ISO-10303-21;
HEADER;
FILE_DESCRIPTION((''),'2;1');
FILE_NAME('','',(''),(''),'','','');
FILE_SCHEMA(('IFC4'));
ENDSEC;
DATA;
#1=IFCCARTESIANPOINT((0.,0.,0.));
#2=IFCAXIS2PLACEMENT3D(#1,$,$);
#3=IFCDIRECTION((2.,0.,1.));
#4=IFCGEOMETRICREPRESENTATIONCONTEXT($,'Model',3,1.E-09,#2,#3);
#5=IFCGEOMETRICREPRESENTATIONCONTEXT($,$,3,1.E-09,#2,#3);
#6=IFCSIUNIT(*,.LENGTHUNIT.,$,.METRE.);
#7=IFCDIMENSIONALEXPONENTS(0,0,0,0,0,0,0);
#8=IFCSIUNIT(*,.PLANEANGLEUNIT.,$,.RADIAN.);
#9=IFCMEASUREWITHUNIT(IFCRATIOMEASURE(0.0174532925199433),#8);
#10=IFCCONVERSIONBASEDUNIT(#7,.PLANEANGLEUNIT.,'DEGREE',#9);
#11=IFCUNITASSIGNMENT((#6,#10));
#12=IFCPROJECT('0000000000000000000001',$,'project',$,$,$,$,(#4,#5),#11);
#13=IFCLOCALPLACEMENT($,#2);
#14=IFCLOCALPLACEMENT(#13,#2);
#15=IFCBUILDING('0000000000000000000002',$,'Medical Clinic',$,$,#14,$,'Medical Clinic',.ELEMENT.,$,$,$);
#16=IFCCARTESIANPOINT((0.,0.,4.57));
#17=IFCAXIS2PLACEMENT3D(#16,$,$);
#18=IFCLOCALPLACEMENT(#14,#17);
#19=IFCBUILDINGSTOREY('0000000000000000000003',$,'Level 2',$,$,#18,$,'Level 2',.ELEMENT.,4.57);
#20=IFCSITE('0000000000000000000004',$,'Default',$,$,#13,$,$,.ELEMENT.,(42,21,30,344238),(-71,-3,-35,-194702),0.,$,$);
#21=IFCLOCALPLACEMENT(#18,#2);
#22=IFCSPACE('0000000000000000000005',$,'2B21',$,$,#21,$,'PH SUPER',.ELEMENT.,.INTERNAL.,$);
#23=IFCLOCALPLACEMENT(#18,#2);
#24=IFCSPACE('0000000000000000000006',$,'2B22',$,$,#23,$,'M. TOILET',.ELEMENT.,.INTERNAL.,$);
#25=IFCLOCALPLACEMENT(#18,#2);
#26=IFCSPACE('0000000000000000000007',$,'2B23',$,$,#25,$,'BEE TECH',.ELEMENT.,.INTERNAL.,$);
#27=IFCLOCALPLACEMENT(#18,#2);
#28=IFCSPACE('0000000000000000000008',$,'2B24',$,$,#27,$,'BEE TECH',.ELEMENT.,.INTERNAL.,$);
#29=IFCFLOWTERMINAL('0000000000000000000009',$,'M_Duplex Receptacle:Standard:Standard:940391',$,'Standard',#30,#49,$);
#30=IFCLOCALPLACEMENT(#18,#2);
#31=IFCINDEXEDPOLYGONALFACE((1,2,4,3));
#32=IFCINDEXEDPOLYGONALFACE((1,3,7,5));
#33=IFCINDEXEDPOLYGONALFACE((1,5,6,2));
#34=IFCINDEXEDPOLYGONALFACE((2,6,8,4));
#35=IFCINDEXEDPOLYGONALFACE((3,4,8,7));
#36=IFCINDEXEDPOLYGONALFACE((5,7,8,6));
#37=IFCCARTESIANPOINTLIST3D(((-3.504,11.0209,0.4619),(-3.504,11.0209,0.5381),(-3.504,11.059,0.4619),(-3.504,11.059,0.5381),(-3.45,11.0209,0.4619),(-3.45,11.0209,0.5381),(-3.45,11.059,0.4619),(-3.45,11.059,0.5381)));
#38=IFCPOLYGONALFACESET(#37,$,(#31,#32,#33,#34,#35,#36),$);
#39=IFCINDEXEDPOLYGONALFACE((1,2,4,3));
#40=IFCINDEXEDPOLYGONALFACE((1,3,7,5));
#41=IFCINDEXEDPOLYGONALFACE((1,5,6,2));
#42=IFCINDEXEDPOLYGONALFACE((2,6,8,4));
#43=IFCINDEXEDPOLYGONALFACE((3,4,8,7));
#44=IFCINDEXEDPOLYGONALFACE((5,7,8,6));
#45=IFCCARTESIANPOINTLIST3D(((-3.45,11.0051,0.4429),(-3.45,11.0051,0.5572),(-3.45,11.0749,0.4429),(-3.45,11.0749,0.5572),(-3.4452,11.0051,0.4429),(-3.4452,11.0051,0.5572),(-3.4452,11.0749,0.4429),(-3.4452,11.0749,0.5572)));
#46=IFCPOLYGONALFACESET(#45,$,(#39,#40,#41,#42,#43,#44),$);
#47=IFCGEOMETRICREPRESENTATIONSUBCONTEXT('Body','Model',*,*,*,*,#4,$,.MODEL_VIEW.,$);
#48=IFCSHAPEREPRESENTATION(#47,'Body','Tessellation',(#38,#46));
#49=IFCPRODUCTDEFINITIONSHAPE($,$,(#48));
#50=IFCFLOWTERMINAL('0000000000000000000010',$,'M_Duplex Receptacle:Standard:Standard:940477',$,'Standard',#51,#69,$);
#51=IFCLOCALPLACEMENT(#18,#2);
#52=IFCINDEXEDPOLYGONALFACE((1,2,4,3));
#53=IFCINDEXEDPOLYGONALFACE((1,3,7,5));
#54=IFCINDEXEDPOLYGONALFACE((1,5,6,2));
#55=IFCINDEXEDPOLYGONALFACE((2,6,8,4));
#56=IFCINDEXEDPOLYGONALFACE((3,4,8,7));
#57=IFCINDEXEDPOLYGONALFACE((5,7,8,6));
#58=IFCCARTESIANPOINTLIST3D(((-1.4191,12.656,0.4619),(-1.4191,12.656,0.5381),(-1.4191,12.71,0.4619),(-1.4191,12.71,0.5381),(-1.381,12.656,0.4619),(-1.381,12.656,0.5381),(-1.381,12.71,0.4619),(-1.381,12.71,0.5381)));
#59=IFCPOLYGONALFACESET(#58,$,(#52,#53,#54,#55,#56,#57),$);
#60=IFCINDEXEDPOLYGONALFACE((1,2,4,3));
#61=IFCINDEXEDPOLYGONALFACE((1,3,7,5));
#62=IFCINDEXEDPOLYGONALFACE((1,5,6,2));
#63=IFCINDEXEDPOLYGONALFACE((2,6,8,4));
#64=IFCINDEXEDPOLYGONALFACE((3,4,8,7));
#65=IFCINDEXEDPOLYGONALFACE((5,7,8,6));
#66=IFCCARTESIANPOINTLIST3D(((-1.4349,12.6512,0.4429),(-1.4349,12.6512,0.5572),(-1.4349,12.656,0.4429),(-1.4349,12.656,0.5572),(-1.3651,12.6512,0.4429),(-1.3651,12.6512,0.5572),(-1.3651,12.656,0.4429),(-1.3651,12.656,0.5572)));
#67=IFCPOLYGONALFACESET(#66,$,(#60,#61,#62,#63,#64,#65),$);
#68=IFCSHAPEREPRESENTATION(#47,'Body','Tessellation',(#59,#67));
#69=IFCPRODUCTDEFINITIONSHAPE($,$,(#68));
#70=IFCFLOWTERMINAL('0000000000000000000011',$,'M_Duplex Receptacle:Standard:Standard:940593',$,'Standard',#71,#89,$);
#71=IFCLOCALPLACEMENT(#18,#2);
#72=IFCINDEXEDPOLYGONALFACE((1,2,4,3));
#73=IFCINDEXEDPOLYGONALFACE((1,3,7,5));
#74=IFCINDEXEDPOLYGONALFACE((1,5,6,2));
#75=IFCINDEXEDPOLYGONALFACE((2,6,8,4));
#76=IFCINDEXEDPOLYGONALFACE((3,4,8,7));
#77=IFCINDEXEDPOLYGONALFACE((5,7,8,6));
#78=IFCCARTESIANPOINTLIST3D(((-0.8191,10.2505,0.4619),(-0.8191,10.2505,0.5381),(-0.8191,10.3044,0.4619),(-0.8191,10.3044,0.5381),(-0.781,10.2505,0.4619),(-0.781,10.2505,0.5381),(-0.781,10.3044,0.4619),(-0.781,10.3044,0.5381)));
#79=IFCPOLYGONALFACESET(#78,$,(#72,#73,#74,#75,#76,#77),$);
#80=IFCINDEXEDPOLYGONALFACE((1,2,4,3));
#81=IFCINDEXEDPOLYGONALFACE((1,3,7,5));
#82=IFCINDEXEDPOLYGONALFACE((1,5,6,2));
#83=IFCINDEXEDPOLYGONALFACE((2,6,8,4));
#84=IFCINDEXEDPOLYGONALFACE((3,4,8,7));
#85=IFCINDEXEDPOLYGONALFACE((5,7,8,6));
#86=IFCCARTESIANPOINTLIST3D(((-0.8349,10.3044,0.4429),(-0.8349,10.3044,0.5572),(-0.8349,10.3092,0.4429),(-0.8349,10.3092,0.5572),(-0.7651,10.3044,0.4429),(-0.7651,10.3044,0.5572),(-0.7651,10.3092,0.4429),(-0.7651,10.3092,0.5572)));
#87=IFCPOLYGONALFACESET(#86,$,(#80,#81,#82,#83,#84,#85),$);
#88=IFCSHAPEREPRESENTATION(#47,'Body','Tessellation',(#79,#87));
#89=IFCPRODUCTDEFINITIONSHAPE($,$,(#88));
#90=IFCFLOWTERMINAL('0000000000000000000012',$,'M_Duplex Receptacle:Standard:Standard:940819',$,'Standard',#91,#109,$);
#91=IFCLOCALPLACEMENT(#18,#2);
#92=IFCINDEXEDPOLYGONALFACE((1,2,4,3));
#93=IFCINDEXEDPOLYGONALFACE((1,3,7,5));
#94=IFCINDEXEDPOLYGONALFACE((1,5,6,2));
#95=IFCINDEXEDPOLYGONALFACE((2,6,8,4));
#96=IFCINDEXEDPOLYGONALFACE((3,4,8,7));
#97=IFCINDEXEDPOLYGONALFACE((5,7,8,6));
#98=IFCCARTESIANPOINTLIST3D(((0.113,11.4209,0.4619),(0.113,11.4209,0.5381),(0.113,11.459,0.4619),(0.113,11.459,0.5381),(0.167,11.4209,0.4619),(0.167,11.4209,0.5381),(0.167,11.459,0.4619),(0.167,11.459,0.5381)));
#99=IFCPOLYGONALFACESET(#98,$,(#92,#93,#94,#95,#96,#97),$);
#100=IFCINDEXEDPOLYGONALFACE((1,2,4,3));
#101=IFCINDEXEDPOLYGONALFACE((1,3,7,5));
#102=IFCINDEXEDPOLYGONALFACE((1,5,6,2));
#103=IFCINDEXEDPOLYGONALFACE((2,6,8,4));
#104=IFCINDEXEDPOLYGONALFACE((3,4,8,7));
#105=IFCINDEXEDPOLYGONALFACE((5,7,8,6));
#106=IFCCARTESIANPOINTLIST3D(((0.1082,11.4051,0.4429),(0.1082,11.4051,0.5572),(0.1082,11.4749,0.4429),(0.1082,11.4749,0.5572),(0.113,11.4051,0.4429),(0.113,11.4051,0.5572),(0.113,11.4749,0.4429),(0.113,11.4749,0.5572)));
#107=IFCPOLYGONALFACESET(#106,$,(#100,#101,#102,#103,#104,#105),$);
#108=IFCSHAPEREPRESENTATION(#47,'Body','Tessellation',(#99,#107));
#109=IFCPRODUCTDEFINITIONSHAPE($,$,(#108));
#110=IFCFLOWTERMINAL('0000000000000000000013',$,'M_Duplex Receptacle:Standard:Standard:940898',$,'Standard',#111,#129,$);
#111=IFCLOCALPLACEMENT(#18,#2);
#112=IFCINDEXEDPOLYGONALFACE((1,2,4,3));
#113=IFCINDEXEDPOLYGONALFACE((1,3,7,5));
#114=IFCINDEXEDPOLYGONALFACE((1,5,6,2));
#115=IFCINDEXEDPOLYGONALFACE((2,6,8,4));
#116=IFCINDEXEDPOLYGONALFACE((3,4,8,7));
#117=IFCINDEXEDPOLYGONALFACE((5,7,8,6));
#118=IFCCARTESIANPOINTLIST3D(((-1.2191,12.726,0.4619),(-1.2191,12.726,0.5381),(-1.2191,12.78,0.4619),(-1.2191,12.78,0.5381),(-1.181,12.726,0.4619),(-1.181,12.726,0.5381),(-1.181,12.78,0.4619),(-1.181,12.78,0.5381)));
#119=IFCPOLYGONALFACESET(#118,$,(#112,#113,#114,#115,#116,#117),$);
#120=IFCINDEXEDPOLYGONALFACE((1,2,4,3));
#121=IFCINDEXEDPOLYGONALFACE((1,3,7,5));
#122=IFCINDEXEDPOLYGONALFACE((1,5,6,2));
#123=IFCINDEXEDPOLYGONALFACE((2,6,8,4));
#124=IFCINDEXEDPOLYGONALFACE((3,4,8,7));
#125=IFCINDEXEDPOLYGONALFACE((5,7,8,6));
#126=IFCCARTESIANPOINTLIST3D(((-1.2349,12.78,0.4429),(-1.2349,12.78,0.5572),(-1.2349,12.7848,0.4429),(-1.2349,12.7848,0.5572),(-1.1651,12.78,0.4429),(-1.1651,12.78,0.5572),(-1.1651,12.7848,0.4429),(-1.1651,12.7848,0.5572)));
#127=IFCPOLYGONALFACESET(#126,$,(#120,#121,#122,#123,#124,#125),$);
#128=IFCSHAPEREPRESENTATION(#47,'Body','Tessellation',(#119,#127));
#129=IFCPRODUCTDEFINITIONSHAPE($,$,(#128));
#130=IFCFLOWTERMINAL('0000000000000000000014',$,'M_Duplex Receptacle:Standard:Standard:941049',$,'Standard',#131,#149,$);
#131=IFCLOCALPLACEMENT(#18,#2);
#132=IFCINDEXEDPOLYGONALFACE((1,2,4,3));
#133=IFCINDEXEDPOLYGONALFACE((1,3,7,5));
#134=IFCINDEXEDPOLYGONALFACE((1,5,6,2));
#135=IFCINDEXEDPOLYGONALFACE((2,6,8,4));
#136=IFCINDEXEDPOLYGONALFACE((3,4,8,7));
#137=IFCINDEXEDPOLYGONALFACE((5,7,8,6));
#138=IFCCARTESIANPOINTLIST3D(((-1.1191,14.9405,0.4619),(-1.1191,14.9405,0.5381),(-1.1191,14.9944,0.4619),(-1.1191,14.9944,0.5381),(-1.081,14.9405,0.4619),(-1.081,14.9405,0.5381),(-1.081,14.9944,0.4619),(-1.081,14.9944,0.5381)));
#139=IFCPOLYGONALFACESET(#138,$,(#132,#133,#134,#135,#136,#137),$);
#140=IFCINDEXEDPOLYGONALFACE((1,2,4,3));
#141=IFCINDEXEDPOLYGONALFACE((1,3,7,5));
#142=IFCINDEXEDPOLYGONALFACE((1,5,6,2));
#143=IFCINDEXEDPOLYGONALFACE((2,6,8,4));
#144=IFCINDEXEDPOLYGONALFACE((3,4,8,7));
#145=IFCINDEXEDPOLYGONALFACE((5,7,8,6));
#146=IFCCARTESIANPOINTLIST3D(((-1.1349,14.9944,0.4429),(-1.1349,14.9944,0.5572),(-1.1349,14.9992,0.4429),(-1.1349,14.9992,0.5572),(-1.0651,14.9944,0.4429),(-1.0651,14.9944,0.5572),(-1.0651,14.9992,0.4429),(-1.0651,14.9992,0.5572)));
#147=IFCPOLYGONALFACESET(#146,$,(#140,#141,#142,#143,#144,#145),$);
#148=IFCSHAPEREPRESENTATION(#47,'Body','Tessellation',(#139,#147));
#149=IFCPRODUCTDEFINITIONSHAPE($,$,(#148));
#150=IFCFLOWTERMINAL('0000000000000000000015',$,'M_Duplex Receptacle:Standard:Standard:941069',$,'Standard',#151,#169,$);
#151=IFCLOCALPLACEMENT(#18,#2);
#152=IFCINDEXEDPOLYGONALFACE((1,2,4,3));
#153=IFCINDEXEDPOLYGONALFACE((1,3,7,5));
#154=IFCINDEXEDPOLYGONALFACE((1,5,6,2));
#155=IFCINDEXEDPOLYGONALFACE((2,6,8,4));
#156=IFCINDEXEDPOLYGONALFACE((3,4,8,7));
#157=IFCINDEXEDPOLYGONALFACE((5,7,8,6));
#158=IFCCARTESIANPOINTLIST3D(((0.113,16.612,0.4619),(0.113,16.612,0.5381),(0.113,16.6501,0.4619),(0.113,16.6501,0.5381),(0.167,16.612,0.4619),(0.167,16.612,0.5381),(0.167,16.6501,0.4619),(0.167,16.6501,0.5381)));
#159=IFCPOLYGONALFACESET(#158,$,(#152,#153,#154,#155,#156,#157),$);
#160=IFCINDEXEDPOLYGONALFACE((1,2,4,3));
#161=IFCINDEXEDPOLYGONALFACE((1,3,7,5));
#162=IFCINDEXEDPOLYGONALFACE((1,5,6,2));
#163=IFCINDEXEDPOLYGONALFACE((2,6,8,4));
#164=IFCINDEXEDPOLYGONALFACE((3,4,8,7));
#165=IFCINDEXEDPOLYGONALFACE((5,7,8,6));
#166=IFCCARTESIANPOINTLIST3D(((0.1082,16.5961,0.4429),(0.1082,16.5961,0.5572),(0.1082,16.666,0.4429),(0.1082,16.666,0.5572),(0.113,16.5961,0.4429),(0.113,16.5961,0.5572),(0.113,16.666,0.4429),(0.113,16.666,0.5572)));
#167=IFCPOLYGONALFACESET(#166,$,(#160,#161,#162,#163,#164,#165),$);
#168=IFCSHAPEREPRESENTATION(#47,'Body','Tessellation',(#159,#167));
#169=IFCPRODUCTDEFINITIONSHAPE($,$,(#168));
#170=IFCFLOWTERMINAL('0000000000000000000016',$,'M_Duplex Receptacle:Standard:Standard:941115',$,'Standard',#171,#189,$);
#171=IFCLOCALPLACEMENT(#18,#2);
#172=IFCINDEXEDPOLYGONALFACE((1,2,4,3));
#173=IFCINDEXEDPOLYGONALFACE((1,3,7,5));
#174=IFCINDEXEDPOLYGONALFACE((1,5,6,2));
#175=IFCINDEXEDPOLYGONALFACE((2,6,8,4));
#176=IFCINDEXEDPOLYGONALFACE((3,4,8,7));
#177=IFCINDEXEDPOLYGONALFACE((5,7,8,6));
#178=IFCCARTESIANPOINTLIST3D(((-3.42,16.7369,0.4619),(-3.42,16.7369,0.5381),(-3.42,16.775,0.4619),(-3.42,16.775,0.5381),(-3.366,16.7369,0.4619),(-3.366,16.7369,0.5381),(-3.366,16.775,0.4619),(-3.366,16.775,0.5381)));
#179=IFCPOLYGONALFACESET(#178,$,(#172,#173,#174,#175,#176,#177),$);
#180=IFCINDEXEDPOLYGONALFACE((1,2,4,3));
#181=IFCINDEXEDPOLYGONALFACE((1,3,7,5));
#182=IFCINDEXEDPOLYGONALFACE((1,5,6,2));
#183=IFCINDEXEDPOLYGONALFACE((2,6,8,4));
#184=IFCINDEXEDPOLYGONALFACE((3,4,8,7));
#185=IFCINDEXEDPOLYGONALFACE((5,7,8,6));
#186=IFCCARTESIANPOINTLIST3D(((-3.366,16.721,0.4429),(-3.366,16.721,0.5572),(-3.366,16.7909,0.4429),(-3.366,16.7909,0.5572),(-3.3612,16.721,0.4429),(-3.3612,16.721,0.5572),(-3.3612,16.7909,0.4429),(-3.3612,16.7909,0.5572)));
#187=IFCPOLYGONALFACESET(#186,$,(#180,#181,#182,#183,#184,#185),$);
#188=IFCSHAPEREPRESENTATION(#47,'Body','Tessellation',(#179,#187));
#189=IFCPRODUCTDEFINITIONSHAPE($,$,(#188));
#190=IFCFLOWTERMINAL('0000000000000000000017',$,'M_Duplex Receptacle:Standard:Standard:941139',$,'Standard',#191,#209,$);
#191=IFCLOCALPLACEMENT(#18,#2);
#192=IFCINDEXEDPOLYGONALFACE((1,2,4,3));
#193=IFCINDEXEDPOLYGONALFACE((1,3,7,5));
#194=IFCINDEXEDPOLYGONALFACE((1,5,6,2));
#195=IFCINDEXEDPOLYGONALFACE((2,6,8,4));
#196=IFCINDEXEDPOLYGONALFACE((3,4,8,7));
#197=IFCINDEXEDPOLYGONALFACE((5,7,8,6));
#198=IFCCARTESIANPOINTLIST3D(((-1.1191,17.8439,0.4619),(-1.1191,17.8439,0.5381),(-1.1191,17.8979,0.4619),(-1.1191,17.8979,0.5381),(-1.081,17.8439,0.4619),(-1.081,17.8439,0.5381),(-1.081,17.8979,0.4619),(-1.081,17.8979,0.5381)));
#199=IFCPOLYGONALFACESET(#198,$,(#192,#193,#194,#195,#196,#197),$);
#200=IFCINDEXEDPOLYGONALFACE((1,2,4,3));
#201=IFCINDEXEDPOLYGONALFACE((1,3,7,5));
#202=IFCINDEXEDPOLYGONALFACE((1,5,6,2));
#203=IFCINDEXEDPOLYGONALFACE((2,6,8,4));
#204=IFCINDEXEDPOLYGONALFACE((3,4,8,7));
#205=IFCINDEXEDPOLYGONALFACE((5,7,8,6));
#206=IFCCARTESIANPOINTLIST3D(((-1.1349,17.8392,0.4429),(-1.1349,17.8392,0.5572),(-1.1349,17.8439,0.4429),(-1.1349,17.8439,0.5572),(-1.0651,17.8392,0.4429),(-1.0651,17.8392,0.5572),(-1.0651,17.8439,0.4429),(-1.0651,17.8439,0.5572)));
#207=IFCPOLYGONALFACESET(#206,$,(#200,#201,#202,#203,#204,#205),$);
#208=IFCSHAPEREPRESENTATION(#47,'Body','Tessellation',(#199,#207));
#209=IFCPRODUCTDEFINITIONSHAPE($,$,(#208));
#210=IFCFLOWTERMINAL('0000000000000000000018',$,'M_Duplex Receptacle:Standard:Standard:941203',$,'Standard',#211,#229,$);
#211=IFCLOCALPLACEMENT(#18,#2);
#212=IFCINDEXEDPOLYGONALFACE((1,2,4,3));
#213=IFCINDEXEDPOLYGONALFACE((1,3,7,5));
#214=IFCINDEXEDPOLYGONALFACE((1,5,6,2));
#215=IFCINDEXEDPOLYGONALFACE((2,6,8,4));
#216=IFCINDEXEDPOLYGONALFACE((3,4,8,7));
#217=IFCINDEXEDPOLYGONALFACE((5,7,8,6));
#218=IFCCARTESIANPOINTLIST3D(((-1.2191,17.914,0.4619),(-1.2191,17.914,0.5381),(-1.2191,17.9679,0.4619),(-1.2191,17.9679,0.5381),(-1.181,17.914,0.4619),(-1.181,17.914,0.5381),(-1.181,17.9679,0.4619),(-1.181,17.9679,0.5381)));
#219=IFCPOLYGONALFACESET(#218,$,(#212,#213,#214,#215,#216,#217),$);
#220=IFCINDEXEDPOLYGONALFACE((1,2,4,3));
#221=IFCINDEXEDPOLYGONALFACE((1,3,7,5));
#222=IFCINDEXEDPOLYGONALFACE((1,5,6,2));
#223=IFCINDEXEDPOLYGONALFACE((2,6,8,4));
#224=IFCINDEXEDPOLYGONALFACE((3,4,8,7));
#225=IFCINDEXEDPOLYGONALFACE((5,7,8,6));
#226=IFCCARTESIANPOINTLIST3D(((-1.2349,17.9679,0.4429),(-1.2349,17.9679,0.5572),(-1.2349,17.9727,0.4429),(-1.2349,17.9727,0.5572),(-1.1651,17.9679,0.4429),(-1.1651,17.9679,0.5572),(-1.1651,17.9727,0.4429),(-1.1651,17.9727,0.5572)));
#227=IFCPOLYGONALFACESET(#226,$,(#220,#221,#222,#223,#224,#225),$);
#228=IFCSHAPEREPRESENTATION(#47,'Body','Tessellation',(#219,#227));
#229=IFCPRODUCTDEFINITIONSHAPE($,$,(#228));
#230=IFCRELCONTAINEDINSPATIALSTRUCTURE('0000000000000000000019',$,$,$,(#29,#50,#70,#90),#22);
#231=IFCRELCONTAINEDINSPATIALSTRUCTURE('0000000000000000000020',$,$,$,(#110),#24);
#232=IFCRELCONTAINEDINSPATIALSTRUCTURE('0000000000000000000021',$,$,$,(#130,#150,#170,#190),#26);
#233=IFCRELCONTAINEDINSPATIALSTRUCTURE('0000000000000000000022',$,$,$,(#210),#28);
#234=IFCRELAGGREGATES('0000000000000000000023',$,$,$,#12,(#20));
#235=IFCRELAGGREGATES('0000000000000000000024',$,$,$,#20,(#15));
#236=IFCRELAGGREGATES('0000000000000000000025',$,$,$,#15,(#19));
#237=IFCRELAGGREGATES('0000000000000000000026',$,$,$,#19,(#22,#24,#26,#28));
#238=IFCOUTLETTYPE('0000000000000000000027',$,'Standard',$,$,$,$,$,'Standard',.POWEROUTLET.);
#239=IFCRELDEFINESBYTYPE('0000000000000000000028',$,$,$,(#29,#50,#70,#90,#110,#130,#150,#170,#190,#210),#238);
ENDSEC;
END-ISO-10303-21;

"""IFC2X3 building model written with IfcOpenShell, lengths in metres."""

from ifc_helpers import new_model, entity, si_unit, converted_unit, direction, frame, frame_2d, origin, origin_2d_with_axis, place, context, subcontext, project, spatial, rectangle, extrude, source, transform, mapped, type_object, type_shapes, element, save


model = new_model("IFC2X3")

# Units and contexts
model_context = context("Model", 3, precision=1e-09, world=origin(), true_north=direction((2.0, 0.0, 1.0)))
context_of_model = context(None, 3, precision=1e-09, world=origin(), true_north=direction((2.0, 0.0, 1.0)))
body_context = subcontext(model_context, "Body", "Model", "MODEL_VIEW")
ifc_project = project(units=[si_unit("LENGTHUNIT", "METRE"), converted_unit("PLANEANGLEUNIT", "DEGREE", entity("IfcRatioMeasure", 0.0174532925199433), si_unit("PLANEANGLEUNIT", "RADIAN"), dimensions=[0, 0, 0, 0, 0, 0, 0])], contexts=[model_context, context_of_model])

# Site, building, storey, space
site_placement = place(None, origin())
site = spatial("IfcSite", under=ifc_project, at=site_placement, Name="Default", CompositionType="ELEMENT", RefLatitude=(42, 21, 30, 344238), RefLongitude=(-71, -3, -35, -194702), RefElevation=0.0)
building_placement = place(site_placement, origin())
building = spatial("IfcBuilding", under=site, at=building_placement, Name="Medical Clinic", LongName="Medical Clinic", CompositionType="ELEMENT")
storey_placement = place(building_placement, frame((0.0, 0.0, 4.57)))
storey = spatial("IfcBuildingStorey", under=building, at=storey_placement, Name="Level 2", LongName="Level 2", CompositionType="ELEMENT", Elevation=4.57)
space_1_placement = place(storey_placement, origin())
space_1 = spatial("IfcSpace", under=storey, at=space_1_placement, Name="2B21", LongName="PH SUPER", CompositionType="ELEMENT", InteriorOrExteriorSpace="INTERNAL")

# Flow terminals
outlet_type_1 = type_object("IfcOutletType", Name="Standard", ElementType="Standard", PredefinedType="POWEROUTLET")
shared_shape_1 = source(origin(), body_context, "Body", "SweptSolid", [
    extrude(rectangle(XDim=0.0381, YDim=0.0762, at=origin_2d_with_axis()), frame((0.0, 0.0, -0.054), z_axis=(0.0, 0.0, 1.0), x_axis=(-1.0, 0.0, 0.0)), (0.0, 0.0, 1.0), 0.054),
    extrude(rectangle(XDim=0.0698, YDim=0.1143, at=frame_2d((0.0, 0.0), x_axis=(1.0, 0.0))), frame((0.0, 0.0, 0.0), z_axis=(0.0, 0.0, 1.0), x_axis=(-1.0, 0.0, 0.0)), (0.0, 0.0, 1.0), 0.0048),
])
type_shapes(outlet_type_1, [shared_shape_1])
for number, where, z_axis, x_axis, name in (
    (1, (-3.45, 11.04, 0.5), (1.0, 0.0, 0.0), (0.0, 1.0, 0.0), "M_Duplex Receptacle:Standard:Standard:940391"),
    (2, (-1.4, 12.656, 0.5), (0.0, -1.0, 0.0), (1.0, 0.0, 0.0), "M_Duplex Receptacle:Standard:Standard:940477"),
    (3, (-0.8, 10.3044, 0.5), (0.0, 1.0, 0.0), (-1.0, 0.0, 0.0), "M_Duplex Receptacle:Standard:Standard:940593"),
    (4, (0.113, 11.44, 0.5), (-1.0, 0.0, 0.0), (0.0, -1.0, 0.0), "M_Duplex Receptacle:Standard:Standard:940819"),
):
    element("IfcFlowTerminal", number, at=place(space_1_placement, frame(where, z_axis=z_axis, x_axis=x_axis)), inside=space_1, type_object=outlet_type_1, Name=name, ObjectType="Standard", context=body_context, shape_type="MappedRepresentation", body=[
        mapped(shared_shape_1, transform((0.0, 0.0, 0.0), scale=1.0)),
    ])

# Shared definitions
space_2_placement = place(storey_placement, origin())
space_2 = spatial("IfcSpace", under=storey, at=space_2_placement, Name="2B22", LongName="M. TOILET", CompositionType="ELEMENT", InteriorOrExteriorSpace="INTERNAL")

# Flow terminal
flow_terminal_1_placement = place(space_2_placement, frame((-1.2, 12.78, 0.5), z_axis=(0.0, 1.0, 0.0), x_axis=(-1.0, 0.0, 0.0)))
element("IfcFlowTerminal", 5, at=flow_terminal_1_placement, inside=space_2, type_object=outlet_type_1, Name="M_Duplex Receptacle:Standard:Standard:940898", ObjectType="Standard", context=body_context, shape_type="MappedRepresentation", body=[
    mapped(shared_shape_1, transform((0.0, 0.0, 0.0), scale=1.0)),
])

# Shared definitions
space_3_placement = place(storey_placement, origin())
space_3 = spatial("IfcSpace", under=storey, at=space_3_placement, Name="2B23", LongName="BEE TECH", CompositionType="ELEMENT", InteriorOrExteriorSpace="INTERNAL")

# Flow terminals
for number, where, z_axis, x_axis, name in (
    (6, (-1.1, 14.9944, 0.5), (0.0, 1.0, 0.0), (-1.0, 0.0, 0.0), "M_Duplex Receptacle:Standard:Standard:941049"),
    (7, (0.113, 16.6311, 0.5), (-1.0, 0.0, 0.0), (0.0, -1.0, 0.0), "M_Duplex Receptacle:Standard:Standard:941069"),
    (8, (-3.366, 16.756, 0.5), (1.0, 0.0, 0.0), (0.0, 1.0, 0.0), "M_Duplex Receptacle:Standard:Standard:941115"),
    (9, (-1.1, 17.8439, 0.5), (0.0, -1.0, 0.0), (1.0, 0.0, 0.0), "M_Duplex Receptacle:Standard:Standard:941139"),
):
    element("IfcFlowTerminal", number, at=place(space_3_placement, frame(where, z_axis=z_axis, x_axis=x_axis)), inside=space_3, type_object=outlet_type_1, Name=name, ObjectType="Standard", context=body_context, shape_type="MappedRepresentation", body=[
        mapped(shared_shape_1, transform((0.0, 0.0, 0.0), scale=1.0)),
    ])

# Shared definitions
space_4_placement = place(storey_placement, origin())
space_4 = spatial("IfcSpace", under=storey, at=space_4_placement, Name="2B24", LongName="BEE TECH", CompositionType="ELEMENT", InteriorOrExteriorSpace="INTERNAL")

# Flow terminal
flow_terminal_2_placement = place(space_4_placement, frame((-1.2, 17.9679, 0.5), z_axis=(0.0, 1.0, 0.0), x_axis=(-1.0, 0.0, 0.0)))
element("IfcFlowTerminal", 10, at=flow_terminal_2_placement, inside=space_4, type_object=outlet_type_1, Name="M_Duplex Receptacle:Standard:Standard:941203", ObjectType="Standard", context=body_context, shape_type="MappedRepresentation", body=[
    mapped(shared_shape_1, transform((0.0, 0.0, 0.0), scale=1.0)),
])

save(model, "model.ifc")
